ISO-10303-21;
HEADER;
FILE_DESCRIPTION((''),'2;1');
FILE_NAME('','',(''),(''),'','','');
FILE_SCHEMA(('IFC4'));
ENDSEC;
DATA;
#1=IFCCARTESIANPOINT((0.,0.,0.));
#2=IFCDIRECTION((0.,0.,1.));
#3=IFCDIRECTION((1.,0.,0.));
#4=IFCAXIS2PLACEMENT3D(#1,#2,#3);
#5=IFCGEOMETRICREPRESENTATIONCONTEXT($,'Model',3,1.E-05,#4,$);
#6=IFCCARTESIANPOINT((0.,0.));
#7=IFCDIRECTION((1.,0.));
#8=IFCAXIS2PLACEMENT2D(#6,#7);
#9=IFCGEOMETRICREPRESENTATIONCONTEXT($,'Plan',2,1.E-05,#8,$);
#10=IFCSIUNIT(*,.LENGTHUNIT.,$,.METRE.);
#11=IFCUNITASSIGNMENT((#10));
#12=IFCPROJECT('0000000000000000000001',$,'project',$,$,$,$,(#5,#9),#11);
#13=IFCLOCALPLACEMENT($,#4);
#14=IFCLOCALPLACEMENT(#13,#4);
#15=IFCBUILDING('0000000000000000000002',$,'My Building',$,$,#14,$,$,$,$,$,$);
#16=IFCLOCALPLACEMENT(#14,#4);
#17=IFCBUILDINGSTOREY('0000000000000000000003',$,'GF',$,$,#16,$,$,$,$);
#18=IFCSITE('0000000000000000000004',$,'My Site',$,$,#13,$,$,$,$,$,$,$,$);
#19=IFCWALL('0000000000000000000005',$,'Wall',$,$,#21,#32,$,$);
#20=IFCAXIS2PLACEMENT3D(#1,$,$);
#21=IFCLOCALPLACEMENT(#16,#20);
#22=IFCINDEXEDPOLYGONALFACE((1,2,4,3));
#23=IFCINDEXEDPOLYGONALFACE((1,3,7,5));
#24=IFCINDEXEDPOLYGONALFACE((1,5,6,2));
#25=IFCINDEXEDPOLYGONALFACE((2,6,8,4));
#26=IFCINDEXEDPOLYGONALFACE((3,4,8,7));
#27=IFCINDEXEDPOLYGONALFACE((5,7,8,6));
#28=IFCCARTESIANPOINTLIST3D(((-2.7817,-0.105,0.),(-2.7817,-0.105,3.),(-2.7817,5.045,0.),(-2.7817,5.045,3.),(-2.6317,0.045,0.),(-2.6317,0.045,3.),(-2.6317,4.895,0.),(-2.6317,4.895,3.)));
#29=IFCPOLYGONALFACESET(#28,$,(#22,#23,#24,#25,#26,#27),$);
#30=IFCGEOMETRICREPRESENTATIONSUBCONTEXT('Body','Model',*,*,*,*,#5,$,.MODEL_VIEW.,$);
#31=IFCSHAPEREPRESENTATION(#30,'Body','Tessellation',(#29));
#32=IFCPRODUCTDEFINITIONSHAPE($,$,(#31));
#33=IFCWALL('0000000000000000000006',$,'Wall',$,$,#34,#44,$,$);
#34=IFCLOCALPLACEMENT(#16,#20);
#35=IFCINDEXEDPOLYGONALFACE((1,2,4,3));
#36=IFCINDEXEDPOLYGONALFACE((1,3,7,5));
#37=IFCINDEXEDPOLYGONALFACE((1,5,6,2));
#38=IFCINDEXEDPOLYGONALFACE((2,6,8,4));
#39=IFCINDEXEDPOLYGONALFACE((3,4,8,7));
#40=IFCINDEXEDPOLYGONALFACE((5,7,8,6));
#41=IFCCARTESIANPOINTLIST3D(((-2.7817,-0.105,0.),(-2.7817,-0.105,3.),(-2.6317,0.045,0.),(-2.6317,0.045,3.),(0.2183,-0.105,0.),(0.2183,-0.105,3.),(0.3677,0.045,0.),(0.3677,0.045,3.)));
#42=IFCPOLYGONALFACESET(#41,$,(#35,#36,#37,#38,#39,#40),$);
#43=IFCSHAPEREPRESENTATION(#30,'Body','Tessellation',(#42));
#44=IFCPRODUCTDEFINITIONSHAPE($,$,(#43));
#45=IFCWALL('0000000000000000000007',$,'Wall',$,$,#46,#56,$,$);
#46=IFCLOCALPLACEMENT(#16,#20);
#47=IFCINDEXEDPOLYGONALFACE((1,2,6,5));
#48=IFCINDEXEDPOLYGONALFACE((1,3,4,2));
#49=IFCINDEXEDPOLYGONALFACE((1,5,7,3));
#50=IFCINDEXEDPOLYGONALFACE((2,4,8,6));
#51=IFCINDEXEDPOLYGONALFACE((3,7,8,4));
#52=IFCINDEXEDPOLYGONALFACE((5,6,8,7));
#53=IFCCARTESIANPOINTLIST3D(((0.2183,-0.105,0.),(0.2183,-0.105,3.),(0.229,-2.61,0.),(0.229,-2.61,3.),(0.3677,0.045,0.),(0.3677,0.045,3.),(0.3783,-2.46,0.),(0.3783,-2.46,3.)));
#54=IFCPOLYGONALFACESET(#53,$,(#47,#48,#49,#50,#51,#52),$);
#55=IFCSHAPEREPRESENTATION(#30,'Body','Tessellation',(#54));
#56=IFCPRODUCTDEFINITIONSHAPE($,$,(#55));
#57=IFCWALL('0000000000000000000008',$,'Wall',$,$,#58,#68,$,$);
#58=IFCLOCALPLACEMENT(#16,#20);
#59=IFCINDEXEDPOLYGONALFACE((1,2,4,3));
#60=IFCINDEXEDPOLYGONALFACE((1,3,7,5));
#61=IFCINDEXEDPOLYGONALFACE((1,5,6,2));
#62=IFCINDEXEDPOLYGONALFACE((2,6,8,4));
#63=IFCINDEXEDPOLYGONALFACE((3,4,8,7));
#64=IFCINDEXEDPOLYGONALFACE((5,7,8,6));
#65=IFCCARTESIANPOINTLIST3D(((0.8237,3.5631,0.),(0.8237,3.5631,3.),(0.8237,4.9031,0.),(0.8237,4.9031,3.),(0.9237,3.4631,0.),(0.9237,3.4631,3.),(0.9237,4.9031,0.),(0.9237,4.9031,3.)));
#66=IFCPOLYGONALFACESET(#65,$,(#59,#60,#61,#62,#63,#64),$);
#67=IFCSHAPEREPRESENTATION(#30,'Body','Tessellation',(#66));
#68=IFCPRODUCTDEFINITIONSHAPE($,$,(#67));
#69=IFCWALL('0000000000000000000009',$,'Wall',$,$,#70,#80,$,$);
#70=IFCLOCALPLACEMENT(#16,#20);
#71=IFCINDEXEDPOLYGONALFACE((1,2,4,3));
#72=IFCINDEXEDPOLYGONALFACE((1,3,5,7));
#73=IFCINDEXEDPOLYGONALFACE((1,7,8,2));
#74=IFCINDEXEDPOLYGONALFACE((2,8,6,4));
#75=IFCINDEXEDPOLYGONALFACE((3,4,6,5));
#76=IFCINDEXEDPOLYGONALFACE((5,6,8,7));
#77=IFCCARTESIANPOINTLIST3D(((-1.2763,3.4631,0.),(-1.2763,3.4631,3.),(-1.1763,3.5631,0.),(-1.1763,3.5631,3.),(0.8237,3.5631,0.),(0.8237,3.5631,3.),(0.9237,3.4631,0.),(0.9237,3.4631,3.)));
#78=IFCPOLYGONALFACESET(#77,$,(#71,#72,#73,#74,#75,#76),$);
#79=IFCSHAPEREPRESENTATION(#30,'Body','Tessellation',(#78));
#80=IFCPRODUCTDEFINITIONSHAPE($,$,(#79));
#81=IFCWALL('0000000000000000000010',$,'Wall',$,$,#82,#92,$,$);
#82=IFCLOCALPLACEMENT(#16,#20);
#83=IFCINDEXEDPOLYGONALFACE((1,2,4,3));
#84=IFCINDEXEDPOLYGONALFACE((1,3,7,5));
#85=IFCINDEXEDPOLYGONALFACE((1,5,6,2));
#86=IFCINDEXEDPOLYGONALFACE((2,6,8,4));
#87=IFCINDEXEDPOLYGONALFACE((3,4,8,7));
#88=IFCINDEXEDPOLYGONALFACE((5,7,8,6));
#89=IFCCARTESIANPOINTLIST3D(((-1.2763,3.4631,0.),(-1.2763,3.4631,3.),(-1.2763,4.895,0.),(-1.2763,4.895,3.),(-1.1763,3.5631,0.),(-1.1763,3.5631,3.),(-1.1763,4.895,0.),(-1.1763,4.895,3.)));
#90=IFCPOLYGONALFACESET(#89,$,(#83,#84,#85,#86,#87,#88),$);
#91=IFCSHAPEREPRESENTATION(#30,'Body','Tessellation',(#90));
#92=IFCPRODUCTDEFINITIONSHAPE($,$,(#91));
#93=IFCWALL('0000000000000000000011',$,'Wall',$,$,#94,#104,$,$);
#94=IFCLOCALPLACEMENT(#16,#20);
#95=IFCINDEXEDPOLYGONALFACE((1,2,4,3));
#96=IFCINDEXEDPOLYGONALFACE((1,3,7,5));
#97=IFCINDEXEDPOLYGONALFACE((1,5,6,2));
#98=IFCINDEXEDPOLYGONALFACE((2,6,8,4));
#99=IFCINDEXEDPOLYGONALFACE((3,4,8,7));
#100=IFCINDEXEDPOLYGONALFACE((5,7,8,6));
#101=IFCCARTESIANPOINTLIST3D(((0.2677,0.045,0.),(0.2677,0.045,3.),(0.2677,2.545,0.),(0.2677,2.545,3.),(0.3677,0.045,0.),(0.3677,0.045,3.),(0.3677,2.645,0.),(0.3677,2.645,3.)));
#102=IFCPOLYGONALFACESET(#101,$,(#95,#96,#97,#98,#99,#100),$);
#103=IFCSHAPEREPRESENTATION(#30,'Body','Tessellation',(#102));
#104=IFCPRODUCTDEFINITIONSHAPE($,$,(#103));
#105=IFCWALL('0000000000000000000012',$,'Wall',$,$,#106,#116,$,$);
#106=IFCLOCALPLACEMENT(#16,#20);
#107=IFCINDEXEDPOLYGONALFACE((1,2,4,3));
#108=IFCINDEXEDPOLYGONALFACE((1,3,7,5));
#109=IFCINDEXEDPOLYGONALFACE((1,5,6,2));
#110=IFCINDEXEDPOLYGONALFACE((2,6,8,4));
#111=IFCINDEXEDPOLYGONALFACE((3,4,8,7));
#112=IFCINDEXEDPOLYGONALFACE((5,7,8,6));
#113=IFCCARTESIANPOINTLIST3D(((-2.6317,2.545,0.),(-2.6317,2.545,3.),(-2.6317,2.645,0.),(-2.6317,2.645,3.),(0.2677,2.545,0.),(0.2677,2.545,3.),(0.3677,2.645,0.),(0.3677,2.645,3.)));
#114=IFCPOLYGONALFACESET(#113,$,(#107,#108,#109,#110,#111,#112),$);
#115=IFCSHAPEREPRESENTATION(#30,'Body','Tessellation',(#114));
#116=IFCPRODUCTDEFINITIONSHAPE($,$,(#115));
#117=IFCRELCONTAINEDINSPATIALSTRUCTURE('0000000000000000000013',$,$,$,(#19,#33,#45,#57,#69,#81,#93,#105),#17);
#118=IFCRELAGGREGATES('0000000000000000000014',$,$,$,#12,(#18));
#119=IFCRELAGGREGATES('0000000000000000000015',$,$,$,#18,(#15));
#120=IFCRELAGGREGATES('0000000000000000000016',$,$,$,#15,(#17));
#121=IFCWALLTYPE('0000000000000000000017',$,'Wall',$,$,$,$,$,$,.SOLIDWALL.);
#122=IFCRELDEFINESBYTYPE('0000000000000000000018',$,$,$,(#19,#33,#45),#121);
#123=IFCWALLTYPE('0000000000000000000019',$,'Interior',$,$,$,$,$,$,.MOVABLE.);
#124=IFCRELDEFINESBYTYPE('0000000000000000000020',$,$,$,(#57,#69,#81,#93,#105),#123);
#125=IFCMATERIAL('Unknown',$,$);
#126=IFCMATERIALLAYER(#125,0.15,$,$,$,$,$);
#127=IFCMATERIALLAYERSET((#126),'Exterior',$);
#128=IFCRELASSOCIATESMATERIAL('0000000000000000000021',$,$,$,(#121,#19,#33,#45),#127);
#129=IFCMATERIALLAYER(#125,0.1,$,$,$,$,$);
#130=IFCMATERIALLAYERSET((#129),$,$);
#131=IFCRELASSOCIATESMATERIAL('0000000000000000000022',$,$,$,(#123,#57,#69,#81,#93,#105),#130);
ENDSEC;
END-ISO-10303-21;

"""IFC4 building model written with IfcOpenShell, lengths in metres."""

from ifc_helpers import new_model, si_unit, frame, origin_with_axes, origin_2d_with_axis, place, context, subcontext, project, spatial, line, indexed_curve, outline, extrude, material, layer, layer_set, layer_usage, type_object, element, save


model = new_model("IFC4")

# Units and contexts
model_context = context("Model", 3, precision=1e-05, world=origin_with_axes())
plan_context = context("Plan", 2, precision=1e-05, world=origin_2d_with_axis())
body_context_1 = subcontext(model_context, "Body", "Model", "MODEL_VIEW")
ifc_project = project(units=[si_unit("LENGTHUNIT", "METRE")], contexts=[model_context, plan_context])

# Site, building, storey
site_placement = place(None, origin_with_axes())
site = spatial("IfcSite", under=ifc_project, at=site_placement, Name="My Site")
building_placement = place(site_placement, origin_with_axes())
building = spatial("IfcBuilding", under=site, at=building_placement, Name="My Building")
storey_placement = place(building_placement, origin_with_axes())
storey = spatial("IfcBuildingStorey", under=building, at=storey_placement, Name="GF")

# Shared definitions
ifc_material = material(Name="Unknown")
ifc_layer_1 = layer(ifc_material, 0.15)
ifc_layer_set_1 = layer_set([ifc_layer_1], Name="Exterior")
wall_type_1 = type_object("IfcWallType", Name="Wall", PredefinedType="SOLIDWALL", material=ifc_layer_set_1)

# Walls
ifc_layer_usage_1 = layer_usage(ifc_layer_set_1, "AXIS2", "POSITIVE", 0.0)
wall_1_placement = place(storey_placement, frame((-2.7817, 5.045, 0.0), z_axis=(0.0, 0.0, 1.0), x_axis=(0.0, -1.0, 0.0)))
element("IfcWall", 1, at=wall_1_placement, inside=storey, type_object=wall_type_1, material=ifc_layer_usage_1, Name="Wall", context=body_context_1, shape_type="SweptSolid", body=[
    extrude(outline(indexed_curve([(0.0, 0.0), (0.15, 0.15), (5.0, 0.15), (5.15, 0.0)], segments=[line(1, 2, 3, 4, 1)])), origin_with_axes(), (0.0, 0.0, 1.0), 3.0),
])
ifc_layer_usage_2 = layer_usage(ifc_layer_set_1, "AXIS2", "POSITIVE", 0.0)
wall_2_placement = place(storey_placement, frame((-2.7817, -0.105, 0.0), z_axis=(0.0, 0.0, 1.0), x_axis=(1.0, 0.0, 0.0)))
element("IfcWall", 2, at=wall_2_placement, inside=storey, type_object=wall_type_1, material=ifc_layer_usage_2, Name="Wall", context=body_context_1, shape_type="SweptSolid", body=[
    extrude(outline(indexed_curve([(0.0, 0.0), (0.15, 0.15), (3.1494, 0.15), (3.0, 0.0)], segments=[line(1, 2, 3, 4, 1)])), origin_with_axes(), (0.0, 0.0, 1.0), 3.0),
])
ifc_layer_usage_3 = layer_usage(ifc_layer_set_1, "AXIS2", "POSITIVE", 0.0)
wall_3_placement = place(storey_placement, frame((0.2183, -0.105, 0.0), z_axis=(0.0, 0.0, 1.0), x_axis=(0.004245, -0.999991, 0.0)))
element("IfcWall", 3, at=wall_3_placement, inside=storey, type_object=wall_type_1, material=ifc_layer_usage_3, Name="Wall", context=body_context_1, shape_type="SweptSolid", body=[
    extrude(outline(indexed_curve([(0.0, 0.0), (-0.1494, 0.15), (2.3557, 0.15), (2.505, 0.0)], segments=[line(1, 2, 3, 4, 1)])), origin_with_axes(), (0.0, 0.0, 1.0), 3.0),
])
ifc_layer_2 = layer(ifc_material, 0.1)
ifc_layer_set_2 = layer_set([ifc_layer_2])
ifc_layer_usage_4 = layer_usage(ifc_layer_set_2, "AXIS2", "POSITIVE", 0.0)
wall_type_2 = type_object("IfcWallType", Name="Interior", PredefinedType="MOVABLE", material=ifc_layer_set_2)
wall_4_placement = place(storey_placement, frame((0.8237, 4.9031, 0.0), z_axis=(0.0, 0.0, 1.0), x_axis=(0.0, -1.0, 0.0)))
element("IfcWall", 4, at=wall_4_placement, inside=storey, type_object=wall_type_2, material=ifc_layer_usage_4, Name="Wall", context=body_context_1, shape_type="SweptSolid", body=[
    extrude(outline(indexed_curve([(0.0, 0.0), (0.0, 0.1), (1.44, 0.1), (1.34, 0.0)], segments=[line(1, 2, 3, 4, 1)])), origin_with_axes(), (0.0, 0.0, 1.0), 3.0),
])
ifc_layer_usage_5 = layer_usage(ifc_layer_set_2, "AXIS2", "POSITIVE", 0.0)
wall_5_placement = place(storey_placement, frame((0.8237, 3.5631, 0.0), z_axis=(0.0, 0.0, 1.0), x_axis=(-1.0, 0.0, 0.0)))
element("IfcWall", 5, at=wall_5_placement, inside=storey, type_object=wall_type_2, material=ifc_layer_usage_5, Name="Wall", context=body_context_1, shape_type="SweptSolid", body=[
    extrude(outline(indexed_curve([(0.0, 0.0), (-0.1, 0.1), (2.1, 0.1), (2.0, 0.0)], segments=[line(1, 2, 3, 4, 1)])), origin_with_axes(), (0.0, 0.0, 1.0), 3.0),
])
ifc_layer_usage_6 = layer_usage(ifc_layer_set_2, "AXIS2", "POSITIVE", 0.0)
wall_6_placement = place(storey_placement, frame((-1.1763, 3.5631, 0.0), z_axis=(0.0, 0.0, 1.0), x_axis=(0.0, 1.0, 0.0)))
element("IfcWall", 6, at=wall_6_placement, inside=storey, type_object=wall_type_2, material=ifc_layer_usage_6, Name="Wall", context=body_context_1, shape_type="SweptSolid", body=[
    extrude(outline(indexed_curve([(0.0, 0.0), (-0.1, 0.1), (1.3318, 0.1), (1.3318, 0.0)], segments=[line(1, 2, 3, 4, 1)])), origin_with_axes(), (0.0, 0.0, 1.0), 3.0),
])
ifc_layer_usage_7 = layer_usage(ifc_layer_set_2, "AXIS2", "POSITIVE", 0.0)
wall_7_placement = place(storey_placement, frame((0.3677, 0.045, 0.0), z_axis=(0.0, 0.0, 1.0), x_axis=(0.0, 1.0, 0.0)))
element("IfcWall", 7, at=wall_7_placement, inside=storey, type_object=wall_type_2, material=ifc_layer_usage_7, Name="Wall", context=body_context_1, shape_type="SweptSolid", body=[
    extrude(outline(indexed_curve([(0.0, 0.0), (0.0, 0.1), (2.5, 0.1), (2.6, 0.0)], segments=[line(1, 2, 3, 4, 1)])), origin_with_axes(), (0.0, 0.0, 1.0), 3.0),
])
ifc_layer_usage_8 = layer_usage(ifc_layer_set_2, "AXIS2", "POSITIVE", 0.0)
wall_8_placement = place(storey_placement, frame((0.3677, 2.645, 0.0), z_axis=(0.0, 0.0, 1.0), x_axis=(-1.0, 0.0, 0.0)))
element("IfcWall", 8, at=wall_8_placement, inside=storey, type_object=wall_type_2, material=ifc_layer_usage_8, Name="Wall", context=body_context_1, shape_type="SweptSolid", body=[
    extrude(outline(indexed_curve([(0.0, 0.0), (0.1, 0.1), (2.9994, 0.1), (2.9994, 0.0)], segments=[line(1, 2, 3, 4, 1)])), origin_with_axes(), (0.0, 0.0, 1.0), 3.0),
])

save(model, "model.ifc")
